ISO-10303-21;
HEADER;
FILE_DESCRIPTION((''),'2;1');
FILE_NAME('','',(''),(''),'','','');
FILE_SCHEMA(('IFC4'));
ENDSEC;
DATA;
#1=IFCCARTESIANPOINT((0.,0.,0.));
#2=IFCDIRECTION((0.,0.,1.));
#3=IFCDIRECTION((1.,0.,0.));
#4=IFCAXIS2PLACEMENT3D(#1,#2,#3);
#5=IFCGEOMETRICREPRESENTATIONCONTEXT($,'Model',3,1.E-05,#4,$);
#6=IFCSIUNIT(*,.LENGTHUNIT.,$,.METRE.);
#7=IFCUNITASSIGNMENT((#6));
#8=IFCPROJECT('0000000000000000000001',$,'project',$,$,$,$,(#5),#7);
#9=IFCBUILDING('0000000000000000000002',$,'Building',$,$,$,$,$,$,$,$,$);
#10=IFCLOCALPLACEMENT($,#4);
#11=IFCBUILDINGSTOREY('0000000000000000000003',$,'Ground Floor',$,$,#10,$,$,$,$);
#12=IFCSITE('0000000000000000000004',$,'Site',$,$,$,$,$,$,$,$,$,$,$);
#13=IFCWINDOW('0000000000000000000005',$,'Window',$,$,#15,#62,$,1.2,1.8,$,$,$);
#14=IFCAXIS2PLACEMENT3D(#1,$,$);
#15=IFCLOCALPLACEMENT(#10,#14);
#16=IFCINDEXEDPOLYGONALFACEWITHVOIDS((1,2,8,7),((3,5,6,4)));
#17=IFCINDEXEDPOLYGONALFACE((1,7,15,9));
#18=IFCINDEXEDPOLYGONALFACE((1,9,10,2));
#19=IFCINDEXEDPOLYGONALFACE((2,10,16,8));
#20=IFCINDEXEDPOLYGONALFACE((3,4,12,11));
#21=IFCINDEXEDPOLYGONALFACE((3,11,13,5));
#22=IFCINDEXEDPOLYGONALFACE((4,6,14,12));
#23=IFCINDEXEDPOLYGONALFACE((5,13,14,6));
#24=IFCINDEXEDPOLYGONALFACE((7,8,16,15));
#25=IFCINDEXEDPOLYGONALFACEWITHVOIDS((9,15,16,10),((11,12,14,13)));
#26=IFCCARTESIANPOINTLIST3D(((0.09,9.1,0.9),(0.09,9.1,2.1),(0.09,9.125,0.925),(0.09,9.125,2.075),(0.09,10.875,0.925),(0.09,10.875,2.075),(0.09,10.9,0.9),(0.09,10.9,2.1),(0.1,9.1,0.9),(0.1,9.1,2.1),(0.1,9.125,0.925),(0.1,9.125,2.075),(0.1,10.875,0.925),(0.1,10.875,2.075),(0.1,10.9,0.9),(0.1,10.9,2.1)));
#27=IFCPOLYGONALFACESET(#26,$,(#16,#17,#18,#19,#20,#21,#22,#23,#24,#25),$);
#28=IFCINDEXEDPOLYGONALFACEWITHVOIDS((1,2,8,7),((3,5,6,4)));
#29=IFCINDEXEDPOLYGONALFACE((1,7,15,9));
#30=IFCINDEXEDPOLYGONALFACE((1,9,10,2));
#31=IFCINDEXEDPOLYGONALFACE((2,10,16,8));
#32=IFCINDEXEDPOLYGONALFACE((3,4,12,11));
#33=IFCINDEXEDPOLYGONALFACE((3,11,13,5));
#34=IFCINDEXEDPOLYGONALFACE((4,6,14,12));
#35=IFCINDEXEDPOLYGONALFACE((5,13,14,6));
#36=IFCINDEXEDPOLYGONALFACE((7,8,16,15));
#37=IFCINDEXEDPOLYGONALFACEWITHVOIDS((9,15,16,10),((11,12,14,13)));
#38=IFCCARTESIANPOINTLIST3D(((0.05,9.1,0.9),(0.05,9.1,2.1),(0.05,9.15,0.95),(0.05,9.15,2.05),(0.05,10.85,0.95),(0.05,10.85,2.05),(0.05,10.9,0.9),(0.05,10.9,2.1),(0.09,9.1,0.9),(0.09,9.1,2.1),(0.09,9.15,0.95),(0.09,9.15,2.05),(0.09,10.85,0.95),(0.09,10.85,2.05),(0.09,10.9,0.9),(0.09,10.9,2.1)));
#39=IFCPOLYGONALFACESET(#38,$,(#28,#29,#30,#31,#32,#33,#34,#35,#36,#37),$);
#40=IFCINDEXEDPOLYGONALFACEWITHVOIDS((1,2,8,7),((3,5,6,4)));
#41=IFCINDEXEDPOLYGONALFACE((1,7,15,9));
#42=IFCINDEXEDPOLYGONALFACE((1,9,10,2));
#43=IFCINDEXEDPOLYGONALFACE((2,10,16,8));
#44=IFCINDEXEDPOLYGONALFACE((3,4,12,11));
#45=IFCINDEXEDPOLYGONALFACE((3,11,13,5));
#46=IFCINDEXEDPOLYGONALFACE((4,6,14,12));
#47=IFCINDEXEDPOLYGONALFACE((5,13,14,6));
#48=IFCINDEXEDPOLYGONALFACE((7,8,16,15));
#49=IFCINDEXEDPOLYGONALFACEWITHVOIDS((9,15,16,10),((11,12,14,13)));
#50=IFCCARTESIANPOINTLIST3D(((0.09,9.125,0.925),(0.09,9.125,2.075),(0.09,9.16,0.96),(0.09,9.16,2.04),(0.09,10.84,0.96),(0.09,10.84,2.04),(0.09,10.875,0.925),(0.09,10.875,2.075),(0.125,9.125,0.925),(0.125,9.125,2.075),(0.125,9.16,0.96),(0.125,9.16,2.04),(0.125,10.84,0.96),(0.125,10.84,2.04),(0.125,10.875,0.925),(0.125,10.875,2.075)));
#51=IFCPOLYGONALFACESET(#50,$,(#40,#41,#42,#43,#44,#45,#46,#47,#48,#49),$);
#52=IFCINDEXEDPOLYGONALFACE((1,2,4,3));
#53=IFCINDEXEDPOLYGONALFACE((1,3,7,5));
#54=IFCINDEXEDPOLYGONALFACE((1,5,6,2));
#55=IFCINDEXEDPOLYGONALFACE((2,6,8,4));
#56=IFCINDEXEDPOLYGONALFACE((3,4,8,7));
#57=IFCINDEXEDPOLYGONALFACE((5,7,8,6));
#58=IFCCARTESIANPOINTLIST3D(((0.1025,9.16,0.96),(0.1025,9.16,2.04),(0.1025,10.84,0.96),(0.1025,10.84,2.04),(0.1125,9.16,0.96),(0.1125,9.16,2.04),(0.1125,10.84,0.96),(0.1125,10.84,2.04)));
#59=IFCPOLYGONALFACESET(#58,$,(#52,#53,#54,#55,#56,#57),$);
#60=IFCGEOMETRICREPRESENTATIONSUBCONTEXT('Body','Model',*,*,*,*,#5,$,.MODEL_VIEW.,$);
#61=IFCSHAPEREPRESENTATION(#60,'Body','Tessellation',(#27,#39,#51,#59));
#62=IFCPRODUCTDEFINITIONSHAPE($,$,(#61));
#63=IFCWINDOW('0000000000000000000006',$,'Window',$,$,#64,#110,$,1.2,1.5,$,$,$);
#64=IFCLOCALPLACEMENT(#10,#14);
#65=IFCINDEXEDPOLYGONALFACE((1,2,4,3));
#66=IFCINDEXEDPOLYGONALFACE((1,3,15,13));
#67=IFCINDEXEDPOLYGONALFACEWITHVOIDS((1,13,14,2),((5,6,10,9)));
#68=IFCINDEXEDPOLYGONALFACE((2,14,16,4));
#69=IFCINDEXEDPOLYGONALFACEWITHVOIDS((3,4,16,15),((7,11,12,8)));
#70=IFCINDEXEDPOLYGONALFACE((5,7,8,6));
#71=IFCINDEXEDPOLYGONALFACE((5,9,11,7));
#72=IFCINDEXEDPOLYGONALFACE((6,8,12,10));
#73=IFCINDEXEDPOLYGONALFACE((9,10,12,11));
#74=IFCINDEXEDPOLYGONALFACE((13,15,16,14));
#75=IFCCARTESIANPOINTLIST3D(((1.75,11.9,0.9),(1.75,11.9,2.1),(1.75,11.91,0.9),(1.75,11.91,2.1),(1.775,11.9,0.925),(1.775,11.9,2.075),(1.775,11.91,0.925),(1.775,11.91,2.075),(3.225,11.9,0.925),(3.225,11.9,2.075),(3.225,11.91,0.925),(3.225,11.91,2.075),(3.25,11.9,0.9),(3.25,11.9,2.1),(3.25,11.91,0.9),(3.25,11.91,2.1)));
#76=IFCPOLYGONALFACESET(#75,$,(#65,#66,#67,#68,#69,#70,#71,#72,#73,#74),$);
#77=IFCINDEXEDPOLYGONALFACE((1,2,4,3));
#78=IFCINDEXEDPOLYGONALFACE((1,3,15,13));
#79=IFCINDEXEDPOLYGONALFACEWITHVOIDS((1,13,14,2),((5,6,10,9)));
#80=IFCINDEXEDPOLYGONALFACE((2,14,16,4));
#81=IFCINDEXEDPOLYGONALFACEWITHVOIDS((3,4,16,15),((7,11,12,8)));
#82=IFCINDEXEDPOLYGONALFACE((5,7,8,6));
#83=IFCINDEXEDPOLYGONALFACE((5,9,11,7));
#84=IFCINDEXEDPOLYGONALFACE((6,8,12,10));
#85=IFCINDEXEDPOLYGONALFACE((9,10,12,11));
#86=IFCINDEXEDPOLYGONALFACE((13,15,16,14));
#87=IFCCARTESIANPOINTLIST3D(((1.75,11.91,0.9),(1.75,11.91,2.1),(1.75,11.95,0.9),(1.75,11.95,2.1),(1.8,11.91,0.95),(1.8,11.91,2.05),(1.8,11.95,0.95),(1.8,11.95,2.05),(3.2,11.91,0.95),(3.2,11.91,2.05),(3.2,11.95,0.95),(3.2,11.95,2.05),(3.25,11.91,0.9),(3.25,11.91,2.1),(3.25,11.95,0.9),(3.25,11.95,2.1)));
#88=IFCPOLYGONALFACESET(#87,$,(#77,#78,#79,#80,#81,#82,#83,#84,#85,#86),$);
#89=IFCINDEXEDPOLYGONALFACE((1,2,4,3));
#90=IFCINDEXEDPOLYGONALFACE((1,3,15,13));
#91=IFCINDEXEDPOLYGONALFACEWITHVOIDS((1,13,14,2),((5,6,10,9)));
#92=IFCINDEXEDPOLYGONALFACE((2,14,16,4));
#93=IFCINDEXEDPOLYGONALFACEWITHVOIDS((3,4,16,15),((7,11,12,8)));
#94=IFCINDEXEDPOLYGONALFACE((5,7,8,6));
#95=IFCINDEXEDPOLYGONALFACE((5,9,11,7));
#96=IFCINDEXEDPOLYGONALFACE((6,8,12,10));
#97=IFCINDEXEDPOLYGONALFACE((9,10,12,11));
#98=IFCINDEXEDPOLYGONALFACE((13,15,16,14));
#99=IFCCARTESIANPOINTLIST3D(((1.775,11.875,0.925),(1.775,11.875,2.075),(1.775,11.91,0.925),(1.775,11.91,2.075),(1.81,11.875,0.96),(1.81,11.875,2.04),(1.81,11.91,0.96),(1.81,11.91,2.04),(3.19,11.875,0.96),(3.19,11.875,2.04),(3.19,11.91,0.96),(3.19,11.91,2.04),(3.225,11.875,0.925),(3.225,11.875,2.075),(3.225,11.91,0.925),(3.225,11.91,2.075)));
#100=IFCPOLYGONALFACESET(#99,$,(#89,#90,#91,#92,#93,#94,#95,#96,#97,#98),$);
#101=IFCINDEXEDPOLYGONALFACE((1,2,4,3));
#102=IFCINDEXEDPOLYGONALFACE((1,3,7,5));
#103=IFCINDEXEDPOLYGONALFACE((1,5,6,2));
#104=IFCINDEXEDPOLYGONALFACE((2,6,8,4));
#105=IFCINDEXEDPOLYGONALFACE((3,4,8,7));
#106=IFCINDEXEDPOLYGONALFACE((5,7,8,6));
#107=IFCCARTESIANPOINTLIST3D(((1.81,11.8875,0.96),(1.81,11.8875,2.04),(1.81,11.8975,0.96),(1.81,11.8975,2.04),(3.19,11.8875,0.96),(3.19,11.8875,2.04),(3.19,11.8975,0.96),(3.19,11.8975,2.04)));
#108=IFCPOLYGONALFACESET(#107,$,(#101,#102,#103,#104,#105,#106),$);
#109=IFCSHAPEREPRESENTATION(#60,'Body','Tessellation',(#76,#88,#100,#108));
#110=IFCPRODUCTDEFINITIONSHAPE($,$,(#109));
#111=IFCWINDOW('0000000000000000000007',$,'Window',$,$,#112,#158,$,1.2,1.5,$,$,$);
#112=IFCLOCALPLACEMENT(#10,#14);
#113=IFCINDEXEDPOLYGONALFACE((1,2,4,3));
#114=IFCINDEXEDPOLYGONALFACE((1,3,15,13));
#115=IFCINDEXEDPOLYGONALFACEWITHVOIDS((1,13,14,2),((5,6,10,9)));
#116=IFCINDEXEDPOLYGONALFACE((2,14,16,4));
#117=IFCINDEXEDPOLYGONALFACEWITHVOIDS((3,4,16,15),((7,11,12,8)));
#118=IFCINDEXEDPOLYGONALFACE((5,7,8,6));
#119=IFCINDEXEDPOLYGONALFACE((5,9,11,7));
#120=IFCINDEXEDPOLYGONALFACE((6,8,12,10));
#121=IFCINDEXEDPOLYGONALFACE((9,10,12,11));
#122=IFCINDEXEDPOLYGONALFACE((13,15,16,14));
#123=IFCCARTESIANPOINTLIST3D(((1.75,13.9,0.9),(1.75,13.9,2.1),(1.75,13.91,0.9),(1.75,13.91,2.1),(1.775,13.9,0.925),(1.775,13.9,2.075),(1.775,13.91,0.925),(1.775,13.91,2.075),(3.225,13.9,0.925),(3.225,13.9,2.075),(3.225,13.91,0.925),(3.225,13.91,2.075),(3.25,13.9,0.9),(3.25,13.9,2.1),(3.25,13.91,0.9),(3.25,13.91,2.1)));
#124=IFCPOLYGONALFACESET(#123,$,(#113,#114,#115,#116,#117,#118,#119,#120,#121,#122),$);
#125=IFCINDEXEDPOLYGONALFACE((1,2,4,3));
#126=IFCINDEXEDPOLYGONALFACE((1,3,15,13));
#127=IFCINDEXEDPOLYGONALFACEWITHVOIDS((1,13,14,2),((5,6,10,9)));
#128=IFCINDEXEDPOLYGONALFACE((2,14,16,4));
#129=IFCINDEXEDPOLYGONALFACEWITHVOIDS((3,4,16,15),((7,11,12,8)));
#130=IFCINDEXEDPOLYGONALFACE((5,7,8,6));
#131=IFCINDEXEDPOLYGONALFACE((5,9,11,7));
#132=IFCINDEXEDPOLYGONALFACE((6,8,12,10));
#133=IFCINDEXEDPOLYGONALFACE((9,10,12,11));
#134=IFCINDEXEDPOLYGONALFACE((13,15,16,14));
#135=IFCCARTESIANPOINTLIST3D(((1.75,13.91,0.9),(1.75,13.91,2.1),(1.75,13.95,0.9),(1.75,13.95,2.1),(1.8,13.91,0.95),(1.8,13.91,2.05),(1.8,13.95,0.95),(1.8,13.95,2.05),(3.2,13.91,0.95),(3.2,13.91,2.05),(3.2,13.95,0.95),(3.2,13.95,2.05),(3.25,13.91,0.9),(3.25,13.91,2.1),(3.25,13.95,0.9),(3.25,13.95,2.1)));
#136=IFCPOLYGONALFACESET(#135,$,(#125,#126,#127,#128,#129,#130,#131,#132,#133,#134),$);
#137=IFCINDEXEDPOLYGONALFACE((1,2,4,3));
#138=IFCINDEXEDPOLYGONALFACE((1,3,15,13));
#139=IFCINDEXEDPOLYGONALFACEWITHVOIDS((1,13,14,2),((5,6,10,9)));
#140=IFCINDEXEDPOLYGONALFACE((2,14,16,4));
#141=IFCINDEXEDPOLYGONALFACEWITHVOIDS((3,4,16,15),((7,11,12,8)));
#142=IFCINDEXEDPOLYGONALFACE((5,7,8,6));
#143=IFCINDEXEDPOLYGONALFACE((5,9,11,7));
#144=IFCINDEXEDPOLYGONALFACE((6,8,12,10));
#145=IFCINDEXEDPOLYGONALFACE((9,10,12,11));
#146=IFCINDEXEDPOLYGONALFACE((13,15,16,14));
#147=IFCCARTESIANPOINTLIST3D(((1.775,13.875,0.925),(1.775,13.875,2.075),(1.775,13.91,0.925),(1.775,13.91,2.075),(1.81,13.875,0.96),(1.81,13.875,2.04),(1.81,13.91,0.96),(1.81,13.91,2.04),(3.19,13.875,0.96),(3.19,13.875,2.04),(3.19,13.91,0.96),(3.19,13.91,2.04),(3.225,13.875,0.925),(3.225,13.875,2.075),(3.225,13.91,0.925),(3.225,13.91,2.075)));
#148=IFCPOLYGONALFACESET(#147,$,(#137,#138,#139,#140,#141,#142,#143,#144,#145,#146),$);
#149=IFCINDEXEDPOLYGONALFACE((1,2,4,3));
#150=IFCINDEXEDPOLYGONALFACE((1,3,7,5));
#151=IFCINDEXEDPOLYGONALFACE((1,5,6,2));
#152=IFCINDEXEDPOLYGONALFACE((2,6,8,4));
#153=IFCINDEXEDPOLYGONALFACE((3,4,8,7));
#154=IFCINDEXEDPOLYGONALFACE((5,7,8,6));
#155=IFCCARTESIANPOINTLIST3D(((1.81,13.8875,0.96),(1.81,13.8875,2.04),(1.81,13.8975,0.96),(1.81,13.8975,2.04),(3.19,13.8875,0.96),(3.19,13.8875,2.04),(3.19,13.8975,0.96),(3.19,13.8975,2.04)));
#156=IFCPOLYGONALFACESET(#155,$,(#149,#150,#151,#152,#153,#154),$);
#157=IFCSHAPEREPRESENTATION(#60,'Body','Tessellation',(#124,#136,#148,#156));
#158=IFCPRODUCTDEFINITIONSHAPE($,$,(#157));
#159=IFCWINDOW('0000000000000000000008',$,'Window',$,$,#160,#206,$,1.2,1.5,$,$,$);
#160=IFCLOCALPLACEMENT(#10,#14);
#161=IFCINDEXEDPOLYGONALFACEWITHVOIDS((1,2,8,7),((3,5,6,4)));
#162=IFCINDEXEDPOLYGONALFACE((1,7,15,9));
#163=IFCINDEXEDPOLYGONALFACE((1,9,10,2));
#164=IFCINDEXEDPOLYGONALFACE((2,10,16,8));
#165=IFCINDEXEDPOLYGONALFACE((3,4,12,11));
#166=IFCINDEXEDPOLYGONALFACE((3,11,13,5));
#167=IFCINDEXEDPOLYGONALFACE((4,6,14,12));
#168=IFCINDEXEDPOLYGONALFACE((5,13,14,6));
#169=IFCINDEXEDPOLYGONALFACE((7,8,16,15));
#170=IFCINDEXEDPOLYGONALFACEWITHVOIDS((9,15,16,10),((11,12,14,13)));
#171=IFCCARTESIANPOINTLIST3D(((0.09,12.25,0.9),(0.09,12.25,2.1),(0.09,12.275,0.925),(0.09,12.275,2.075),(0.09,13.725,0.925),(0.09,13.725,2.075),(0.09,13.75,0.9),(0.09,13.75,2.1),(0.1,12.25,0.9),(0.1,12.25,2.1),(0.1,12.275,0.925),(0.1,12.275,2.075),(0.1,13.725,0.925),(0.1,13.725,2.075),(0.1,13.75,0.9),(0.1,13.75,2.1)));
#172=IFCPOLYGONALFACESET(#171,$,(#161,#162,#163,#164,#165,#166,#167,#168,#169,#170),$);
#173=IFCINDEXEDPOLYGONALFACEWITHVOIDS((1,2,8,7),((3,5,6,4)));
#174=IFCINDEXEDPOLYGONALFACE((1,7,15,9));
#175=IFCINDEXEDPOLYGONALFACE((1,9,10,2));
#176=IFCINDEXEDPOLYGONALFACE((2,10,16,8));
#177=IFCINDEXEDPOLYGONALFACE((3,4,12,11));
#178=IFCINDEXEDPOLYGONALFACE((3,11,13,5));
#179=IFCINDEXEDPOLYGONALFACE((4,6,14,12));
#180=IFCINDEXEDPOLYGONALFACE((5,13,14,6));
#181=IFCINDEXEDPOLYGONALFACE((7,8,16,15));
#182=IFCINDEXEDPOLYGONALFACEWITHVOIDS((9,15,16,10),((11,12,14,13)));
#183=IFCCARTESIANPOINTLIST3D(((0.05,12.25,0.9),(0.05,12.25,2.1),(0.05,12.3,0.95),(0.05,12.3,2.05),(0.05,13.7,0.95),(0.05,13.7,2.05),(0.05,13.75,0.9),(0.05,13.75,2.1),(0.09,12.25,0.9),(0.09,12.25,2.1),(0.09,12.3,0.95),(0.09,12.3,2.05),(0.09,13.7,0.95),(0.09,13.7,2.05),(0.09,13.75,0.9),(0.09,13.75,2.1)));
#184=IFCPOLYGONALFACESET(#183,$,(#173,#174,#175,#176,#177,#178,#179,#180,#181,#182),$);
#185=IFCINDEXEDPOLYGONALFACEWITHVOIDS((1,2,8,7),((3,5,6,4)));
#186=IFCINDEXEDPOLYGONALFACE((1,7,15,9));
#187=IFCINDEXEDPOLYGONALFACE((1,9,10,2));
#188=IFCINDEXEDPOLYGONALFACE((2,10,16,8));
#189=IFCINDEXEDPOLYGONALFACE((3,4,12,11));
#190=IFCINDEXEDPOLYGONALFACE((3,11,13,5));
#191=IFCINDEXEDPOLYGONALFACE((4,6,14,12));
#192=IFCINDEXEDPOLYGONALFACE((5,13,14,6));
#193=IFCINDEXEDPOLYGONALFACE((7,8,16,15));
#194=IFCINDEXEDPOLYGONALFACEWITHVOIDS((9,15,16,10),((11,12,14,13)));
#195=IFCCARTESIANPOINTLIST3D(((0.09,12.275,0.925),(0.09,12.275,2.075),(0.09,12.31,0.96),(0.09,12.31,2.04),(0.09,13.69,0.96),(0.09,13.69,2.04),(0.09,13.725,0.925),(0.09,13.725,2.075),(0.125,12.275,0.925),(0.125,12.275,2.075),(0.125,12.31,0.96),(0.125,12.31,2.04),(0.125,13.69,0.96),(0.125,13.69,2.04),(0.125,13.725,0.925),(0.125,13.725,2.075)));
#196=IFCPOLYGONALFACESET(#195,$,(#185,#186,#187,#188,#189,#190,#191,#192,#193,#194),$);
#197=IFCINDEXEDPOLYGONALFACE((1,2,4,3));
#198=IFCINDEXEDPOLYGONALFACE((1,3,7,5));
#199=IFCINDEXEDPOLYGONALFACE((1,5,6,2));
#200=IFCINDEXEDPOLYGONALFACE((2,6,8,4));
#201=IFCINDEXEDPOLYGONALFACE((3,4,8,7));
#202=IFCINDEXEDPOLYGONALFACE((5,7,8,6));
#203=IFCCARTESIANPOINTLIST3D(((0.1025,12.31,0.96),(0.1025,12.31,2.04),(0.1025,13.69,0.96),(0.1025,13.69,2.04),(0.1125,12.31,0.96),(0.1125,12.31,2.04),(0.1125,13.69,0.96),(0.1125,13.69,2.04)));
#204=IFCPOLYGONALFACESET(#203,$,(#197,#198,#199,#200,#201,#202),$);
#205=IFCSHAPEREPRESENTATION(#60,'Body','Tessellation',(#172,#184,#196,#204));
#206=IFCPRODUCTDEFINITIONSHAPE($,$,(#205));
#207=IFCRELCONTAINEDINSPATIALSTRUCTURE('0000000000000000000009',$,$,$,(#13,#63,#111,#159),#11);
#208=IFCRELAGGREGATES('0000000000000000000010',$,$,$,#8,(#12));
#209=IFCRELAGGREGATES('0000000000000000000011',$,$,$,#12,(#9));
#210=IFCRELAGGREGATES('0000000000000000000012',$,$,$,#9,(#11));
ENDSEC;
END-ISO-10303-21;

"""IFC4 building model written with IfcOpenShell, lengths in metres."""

from ifc_helpers import new_model, si_unit, frame, origin_with_axes, place, context, subcontext, project, spatial, line, indexed_curve, outline, extrude, element, save


model = new_model("IFC4")

# Units and contexts
model_context = context("Model", 3, precision=1e-05, world=origin_with_axes())
body_context = subcontext(model_context, "Body", "Model", "MODEL_VIEW")
ifc_project = project(units=[si_unit("LENGTHUNIT", "METRE")], contexts=[model_context])

# Site, building, storey
site = spatial("IfcSite", under=ifc_project, Name="Site")
building = spatial("IfcBuilding", under=site, Name="Building")
storey_placement = place(None, origin_with_axes())
storey = spatial("IfcBuildingStorey", under=building, at=storey_placement, Name="Ground Floor")

# Windows
window_1_placement = place(storey_placement, frame((0.0, 10.9, 0.9), z_axis=(0.0, 0.0, 1.0), x_axis=(0.0, -1.0, 0.0)))
element("IfcWindow", 1, at=window_1_placement, inside=storey, Name="Window", OverallHeight=1.2, OverallWidth=1.8, context=body_context, shape_type="SweptSolid", body=[
    extrude(outline(indexed_curve([(0.0, 0.0), (1.8, 0.0), (1.8, 1.2), (0.0, 1.2)], segments=[line(1, 2, 3, 4, 1)]), holes=[indexed_curve([(0.025, 0.025), (1.775, 0.025), (1.775, 1.175), (0.025, 1.175)], segments=[line(1, 2, 3, 4, 1)])]), frame((0.0, 0.09, 0.0), z_axis=(0.0, -1.0, 0.0), x_axis=(1.0, 0.0, 0.0)), (0.0, 0.0, -1.0), 0.01),
    extrude(outline(indexed_curve([(0.0, 0.0), (1.8, 0.0), (1.8, 1.2), (0.0, 1.2)], segments=[line(1, 2, 3, 4, 1)]), holes=[indexed_curve([(0.05, 0.05), (1.75, 0.05), (1.75, 1.15), (0.05, 1.15)], segments=[line(1, 2, 3, 4, 1)])]), frame((0.0, 0.05, 0.0), z_axis=(0.0, -1.0, 0.0), x_axis=(1.0, 0.0, 0.0)), (0.0, 0.0, -1.0), 0.04),
    extrude(outline(indexed_curve([(0.0, 0.0), (1.75, 0.0), (1.75, 1.15), (0.0, 1.15)], segments=[line(1, 2, 3, 4, 1)]), holes=[indexed_curve([(0.035, 0.035), (1.715, 0.035), (1.715, 1.115), (0.035, 1.115)], segments=[line(1, 2, 3, 4, 1)])]), frame((0.025, 0.09, 0.025), z_axis=(0.0, -1.0, 0.0), x_axis=(1.0, 0.0, 0.0)), (0.0, 0.0, -1.0), 0.035),
    extrude(outline(indexed_curve([(0.035, 0.035), (1.715, 0.035), (1.715, 1.115), (0.035, 1.115)], segments=[line(1, 2, 3, 4, 1)])), frame((0.025, 0.1025, 0.025), z_axis=(0.0, -1.0, 0.0), x_axis=(1.0, 0.0, 0.0)), (0.0, 0.0, -1.0), 0.01),
])
for number, where, z_axis, x_axis, name in (
    (2, (3.25, 12.0, 0.9), (0.0, 0.0, 1.0), (-1.0, 0.0, 0.0), "Window"),
    (3, (3.25, 14.0, 0.9), (0.0, 0.0, 1.0), (-1.0, 0.0, 0.0), "Window"),
    (4, (0.0, 13.75, 0.9), (0.0, 0.0, 1.0), (0.0, -1.0, 0.0), "Window"),
):
    element("IfcWindow", number, at=place(storey_placement, frame(where, z_axis=z_axis, x_axis=x_axis)), inside=storey, Name=name, OverallHeight=1.2, OverallWidth=1.5, context=body_context, shape_type="SweptSolid", body=[
        extrude(outline(indexed_curve([(0.0, 0.0), (1.5, 0.0), (1.5, 1.2), (0.0, 1.2)], segments=[line(1, 2, 3, 4, 1)]), holes=[indexed_curve([(0.025, 0.025), (1.475, 0.025), (1.475, 1.175), (0.025, 1.175)], segments=[line(1, 2, 3, 4, 1)])]), frame((0.0, 0.09, 0.0), z_axis=(0.0, -1.0, 0.0), x_axis=(1.0, 0.0, 0.0)), (0.0, 0.0, -1.0), 0.01),
        extrude(outline(indexed_curve([(0.0, 0.0), (1.5, 0.0), (1.5, 1.2), (0.0, 1.2)], segments=[line(1, 2, 3, 4, 1)]), holes=[indexed_curve([(0.05, 0.05), (1.45, 0.05), (1.45, 1.15), (0.05, 1.15)], segments=[line(1, 2, 3, 4, 1)])]), frame((0.0, 0.05, 0.0), z_axis=(0.0, -1.0, 0.0), x_axis=(1.0, 0.0, 0.0)), (0.0, 0.0, -1.0), 0.04),
        extrude(outline(indexed_curve([(0.0, 0.0), (1.45, 0.0), (1.45, 1.15), (0.0, 1.15)], segments=[line(1, 2, 3, 4, 1)]), holes=[indexed_curve([(0.035, 0.035), (1.415, 0.035), (1.415, 1.115), (0.035, 1.115)], segments=[line(1, 2, 3, 4, 1)])]), frame((0.025, 0.09, 0.025), z_axis=(0.0, -1.0, 0.0), x_axis=(1.0, 0.0, 0.0)), (0.0, 0.0, -1.0), 0.035),
        extrude(outline(indexed_curve([(0.035, 0.035), (1.415, 0.035), (1.415, 1.115), (0.035, 1.115)], segments=[line(1, 2, 3, 4, 1)])), frame((0.025, 0.1025, 0.025), z_axis=(0.0, -1.0, 0.0), x_axis=(1.0, 0.0, 0.0)), (0.0, 0.0, -1.0), 0.01),
    ])

save(model, "model.ifc")
